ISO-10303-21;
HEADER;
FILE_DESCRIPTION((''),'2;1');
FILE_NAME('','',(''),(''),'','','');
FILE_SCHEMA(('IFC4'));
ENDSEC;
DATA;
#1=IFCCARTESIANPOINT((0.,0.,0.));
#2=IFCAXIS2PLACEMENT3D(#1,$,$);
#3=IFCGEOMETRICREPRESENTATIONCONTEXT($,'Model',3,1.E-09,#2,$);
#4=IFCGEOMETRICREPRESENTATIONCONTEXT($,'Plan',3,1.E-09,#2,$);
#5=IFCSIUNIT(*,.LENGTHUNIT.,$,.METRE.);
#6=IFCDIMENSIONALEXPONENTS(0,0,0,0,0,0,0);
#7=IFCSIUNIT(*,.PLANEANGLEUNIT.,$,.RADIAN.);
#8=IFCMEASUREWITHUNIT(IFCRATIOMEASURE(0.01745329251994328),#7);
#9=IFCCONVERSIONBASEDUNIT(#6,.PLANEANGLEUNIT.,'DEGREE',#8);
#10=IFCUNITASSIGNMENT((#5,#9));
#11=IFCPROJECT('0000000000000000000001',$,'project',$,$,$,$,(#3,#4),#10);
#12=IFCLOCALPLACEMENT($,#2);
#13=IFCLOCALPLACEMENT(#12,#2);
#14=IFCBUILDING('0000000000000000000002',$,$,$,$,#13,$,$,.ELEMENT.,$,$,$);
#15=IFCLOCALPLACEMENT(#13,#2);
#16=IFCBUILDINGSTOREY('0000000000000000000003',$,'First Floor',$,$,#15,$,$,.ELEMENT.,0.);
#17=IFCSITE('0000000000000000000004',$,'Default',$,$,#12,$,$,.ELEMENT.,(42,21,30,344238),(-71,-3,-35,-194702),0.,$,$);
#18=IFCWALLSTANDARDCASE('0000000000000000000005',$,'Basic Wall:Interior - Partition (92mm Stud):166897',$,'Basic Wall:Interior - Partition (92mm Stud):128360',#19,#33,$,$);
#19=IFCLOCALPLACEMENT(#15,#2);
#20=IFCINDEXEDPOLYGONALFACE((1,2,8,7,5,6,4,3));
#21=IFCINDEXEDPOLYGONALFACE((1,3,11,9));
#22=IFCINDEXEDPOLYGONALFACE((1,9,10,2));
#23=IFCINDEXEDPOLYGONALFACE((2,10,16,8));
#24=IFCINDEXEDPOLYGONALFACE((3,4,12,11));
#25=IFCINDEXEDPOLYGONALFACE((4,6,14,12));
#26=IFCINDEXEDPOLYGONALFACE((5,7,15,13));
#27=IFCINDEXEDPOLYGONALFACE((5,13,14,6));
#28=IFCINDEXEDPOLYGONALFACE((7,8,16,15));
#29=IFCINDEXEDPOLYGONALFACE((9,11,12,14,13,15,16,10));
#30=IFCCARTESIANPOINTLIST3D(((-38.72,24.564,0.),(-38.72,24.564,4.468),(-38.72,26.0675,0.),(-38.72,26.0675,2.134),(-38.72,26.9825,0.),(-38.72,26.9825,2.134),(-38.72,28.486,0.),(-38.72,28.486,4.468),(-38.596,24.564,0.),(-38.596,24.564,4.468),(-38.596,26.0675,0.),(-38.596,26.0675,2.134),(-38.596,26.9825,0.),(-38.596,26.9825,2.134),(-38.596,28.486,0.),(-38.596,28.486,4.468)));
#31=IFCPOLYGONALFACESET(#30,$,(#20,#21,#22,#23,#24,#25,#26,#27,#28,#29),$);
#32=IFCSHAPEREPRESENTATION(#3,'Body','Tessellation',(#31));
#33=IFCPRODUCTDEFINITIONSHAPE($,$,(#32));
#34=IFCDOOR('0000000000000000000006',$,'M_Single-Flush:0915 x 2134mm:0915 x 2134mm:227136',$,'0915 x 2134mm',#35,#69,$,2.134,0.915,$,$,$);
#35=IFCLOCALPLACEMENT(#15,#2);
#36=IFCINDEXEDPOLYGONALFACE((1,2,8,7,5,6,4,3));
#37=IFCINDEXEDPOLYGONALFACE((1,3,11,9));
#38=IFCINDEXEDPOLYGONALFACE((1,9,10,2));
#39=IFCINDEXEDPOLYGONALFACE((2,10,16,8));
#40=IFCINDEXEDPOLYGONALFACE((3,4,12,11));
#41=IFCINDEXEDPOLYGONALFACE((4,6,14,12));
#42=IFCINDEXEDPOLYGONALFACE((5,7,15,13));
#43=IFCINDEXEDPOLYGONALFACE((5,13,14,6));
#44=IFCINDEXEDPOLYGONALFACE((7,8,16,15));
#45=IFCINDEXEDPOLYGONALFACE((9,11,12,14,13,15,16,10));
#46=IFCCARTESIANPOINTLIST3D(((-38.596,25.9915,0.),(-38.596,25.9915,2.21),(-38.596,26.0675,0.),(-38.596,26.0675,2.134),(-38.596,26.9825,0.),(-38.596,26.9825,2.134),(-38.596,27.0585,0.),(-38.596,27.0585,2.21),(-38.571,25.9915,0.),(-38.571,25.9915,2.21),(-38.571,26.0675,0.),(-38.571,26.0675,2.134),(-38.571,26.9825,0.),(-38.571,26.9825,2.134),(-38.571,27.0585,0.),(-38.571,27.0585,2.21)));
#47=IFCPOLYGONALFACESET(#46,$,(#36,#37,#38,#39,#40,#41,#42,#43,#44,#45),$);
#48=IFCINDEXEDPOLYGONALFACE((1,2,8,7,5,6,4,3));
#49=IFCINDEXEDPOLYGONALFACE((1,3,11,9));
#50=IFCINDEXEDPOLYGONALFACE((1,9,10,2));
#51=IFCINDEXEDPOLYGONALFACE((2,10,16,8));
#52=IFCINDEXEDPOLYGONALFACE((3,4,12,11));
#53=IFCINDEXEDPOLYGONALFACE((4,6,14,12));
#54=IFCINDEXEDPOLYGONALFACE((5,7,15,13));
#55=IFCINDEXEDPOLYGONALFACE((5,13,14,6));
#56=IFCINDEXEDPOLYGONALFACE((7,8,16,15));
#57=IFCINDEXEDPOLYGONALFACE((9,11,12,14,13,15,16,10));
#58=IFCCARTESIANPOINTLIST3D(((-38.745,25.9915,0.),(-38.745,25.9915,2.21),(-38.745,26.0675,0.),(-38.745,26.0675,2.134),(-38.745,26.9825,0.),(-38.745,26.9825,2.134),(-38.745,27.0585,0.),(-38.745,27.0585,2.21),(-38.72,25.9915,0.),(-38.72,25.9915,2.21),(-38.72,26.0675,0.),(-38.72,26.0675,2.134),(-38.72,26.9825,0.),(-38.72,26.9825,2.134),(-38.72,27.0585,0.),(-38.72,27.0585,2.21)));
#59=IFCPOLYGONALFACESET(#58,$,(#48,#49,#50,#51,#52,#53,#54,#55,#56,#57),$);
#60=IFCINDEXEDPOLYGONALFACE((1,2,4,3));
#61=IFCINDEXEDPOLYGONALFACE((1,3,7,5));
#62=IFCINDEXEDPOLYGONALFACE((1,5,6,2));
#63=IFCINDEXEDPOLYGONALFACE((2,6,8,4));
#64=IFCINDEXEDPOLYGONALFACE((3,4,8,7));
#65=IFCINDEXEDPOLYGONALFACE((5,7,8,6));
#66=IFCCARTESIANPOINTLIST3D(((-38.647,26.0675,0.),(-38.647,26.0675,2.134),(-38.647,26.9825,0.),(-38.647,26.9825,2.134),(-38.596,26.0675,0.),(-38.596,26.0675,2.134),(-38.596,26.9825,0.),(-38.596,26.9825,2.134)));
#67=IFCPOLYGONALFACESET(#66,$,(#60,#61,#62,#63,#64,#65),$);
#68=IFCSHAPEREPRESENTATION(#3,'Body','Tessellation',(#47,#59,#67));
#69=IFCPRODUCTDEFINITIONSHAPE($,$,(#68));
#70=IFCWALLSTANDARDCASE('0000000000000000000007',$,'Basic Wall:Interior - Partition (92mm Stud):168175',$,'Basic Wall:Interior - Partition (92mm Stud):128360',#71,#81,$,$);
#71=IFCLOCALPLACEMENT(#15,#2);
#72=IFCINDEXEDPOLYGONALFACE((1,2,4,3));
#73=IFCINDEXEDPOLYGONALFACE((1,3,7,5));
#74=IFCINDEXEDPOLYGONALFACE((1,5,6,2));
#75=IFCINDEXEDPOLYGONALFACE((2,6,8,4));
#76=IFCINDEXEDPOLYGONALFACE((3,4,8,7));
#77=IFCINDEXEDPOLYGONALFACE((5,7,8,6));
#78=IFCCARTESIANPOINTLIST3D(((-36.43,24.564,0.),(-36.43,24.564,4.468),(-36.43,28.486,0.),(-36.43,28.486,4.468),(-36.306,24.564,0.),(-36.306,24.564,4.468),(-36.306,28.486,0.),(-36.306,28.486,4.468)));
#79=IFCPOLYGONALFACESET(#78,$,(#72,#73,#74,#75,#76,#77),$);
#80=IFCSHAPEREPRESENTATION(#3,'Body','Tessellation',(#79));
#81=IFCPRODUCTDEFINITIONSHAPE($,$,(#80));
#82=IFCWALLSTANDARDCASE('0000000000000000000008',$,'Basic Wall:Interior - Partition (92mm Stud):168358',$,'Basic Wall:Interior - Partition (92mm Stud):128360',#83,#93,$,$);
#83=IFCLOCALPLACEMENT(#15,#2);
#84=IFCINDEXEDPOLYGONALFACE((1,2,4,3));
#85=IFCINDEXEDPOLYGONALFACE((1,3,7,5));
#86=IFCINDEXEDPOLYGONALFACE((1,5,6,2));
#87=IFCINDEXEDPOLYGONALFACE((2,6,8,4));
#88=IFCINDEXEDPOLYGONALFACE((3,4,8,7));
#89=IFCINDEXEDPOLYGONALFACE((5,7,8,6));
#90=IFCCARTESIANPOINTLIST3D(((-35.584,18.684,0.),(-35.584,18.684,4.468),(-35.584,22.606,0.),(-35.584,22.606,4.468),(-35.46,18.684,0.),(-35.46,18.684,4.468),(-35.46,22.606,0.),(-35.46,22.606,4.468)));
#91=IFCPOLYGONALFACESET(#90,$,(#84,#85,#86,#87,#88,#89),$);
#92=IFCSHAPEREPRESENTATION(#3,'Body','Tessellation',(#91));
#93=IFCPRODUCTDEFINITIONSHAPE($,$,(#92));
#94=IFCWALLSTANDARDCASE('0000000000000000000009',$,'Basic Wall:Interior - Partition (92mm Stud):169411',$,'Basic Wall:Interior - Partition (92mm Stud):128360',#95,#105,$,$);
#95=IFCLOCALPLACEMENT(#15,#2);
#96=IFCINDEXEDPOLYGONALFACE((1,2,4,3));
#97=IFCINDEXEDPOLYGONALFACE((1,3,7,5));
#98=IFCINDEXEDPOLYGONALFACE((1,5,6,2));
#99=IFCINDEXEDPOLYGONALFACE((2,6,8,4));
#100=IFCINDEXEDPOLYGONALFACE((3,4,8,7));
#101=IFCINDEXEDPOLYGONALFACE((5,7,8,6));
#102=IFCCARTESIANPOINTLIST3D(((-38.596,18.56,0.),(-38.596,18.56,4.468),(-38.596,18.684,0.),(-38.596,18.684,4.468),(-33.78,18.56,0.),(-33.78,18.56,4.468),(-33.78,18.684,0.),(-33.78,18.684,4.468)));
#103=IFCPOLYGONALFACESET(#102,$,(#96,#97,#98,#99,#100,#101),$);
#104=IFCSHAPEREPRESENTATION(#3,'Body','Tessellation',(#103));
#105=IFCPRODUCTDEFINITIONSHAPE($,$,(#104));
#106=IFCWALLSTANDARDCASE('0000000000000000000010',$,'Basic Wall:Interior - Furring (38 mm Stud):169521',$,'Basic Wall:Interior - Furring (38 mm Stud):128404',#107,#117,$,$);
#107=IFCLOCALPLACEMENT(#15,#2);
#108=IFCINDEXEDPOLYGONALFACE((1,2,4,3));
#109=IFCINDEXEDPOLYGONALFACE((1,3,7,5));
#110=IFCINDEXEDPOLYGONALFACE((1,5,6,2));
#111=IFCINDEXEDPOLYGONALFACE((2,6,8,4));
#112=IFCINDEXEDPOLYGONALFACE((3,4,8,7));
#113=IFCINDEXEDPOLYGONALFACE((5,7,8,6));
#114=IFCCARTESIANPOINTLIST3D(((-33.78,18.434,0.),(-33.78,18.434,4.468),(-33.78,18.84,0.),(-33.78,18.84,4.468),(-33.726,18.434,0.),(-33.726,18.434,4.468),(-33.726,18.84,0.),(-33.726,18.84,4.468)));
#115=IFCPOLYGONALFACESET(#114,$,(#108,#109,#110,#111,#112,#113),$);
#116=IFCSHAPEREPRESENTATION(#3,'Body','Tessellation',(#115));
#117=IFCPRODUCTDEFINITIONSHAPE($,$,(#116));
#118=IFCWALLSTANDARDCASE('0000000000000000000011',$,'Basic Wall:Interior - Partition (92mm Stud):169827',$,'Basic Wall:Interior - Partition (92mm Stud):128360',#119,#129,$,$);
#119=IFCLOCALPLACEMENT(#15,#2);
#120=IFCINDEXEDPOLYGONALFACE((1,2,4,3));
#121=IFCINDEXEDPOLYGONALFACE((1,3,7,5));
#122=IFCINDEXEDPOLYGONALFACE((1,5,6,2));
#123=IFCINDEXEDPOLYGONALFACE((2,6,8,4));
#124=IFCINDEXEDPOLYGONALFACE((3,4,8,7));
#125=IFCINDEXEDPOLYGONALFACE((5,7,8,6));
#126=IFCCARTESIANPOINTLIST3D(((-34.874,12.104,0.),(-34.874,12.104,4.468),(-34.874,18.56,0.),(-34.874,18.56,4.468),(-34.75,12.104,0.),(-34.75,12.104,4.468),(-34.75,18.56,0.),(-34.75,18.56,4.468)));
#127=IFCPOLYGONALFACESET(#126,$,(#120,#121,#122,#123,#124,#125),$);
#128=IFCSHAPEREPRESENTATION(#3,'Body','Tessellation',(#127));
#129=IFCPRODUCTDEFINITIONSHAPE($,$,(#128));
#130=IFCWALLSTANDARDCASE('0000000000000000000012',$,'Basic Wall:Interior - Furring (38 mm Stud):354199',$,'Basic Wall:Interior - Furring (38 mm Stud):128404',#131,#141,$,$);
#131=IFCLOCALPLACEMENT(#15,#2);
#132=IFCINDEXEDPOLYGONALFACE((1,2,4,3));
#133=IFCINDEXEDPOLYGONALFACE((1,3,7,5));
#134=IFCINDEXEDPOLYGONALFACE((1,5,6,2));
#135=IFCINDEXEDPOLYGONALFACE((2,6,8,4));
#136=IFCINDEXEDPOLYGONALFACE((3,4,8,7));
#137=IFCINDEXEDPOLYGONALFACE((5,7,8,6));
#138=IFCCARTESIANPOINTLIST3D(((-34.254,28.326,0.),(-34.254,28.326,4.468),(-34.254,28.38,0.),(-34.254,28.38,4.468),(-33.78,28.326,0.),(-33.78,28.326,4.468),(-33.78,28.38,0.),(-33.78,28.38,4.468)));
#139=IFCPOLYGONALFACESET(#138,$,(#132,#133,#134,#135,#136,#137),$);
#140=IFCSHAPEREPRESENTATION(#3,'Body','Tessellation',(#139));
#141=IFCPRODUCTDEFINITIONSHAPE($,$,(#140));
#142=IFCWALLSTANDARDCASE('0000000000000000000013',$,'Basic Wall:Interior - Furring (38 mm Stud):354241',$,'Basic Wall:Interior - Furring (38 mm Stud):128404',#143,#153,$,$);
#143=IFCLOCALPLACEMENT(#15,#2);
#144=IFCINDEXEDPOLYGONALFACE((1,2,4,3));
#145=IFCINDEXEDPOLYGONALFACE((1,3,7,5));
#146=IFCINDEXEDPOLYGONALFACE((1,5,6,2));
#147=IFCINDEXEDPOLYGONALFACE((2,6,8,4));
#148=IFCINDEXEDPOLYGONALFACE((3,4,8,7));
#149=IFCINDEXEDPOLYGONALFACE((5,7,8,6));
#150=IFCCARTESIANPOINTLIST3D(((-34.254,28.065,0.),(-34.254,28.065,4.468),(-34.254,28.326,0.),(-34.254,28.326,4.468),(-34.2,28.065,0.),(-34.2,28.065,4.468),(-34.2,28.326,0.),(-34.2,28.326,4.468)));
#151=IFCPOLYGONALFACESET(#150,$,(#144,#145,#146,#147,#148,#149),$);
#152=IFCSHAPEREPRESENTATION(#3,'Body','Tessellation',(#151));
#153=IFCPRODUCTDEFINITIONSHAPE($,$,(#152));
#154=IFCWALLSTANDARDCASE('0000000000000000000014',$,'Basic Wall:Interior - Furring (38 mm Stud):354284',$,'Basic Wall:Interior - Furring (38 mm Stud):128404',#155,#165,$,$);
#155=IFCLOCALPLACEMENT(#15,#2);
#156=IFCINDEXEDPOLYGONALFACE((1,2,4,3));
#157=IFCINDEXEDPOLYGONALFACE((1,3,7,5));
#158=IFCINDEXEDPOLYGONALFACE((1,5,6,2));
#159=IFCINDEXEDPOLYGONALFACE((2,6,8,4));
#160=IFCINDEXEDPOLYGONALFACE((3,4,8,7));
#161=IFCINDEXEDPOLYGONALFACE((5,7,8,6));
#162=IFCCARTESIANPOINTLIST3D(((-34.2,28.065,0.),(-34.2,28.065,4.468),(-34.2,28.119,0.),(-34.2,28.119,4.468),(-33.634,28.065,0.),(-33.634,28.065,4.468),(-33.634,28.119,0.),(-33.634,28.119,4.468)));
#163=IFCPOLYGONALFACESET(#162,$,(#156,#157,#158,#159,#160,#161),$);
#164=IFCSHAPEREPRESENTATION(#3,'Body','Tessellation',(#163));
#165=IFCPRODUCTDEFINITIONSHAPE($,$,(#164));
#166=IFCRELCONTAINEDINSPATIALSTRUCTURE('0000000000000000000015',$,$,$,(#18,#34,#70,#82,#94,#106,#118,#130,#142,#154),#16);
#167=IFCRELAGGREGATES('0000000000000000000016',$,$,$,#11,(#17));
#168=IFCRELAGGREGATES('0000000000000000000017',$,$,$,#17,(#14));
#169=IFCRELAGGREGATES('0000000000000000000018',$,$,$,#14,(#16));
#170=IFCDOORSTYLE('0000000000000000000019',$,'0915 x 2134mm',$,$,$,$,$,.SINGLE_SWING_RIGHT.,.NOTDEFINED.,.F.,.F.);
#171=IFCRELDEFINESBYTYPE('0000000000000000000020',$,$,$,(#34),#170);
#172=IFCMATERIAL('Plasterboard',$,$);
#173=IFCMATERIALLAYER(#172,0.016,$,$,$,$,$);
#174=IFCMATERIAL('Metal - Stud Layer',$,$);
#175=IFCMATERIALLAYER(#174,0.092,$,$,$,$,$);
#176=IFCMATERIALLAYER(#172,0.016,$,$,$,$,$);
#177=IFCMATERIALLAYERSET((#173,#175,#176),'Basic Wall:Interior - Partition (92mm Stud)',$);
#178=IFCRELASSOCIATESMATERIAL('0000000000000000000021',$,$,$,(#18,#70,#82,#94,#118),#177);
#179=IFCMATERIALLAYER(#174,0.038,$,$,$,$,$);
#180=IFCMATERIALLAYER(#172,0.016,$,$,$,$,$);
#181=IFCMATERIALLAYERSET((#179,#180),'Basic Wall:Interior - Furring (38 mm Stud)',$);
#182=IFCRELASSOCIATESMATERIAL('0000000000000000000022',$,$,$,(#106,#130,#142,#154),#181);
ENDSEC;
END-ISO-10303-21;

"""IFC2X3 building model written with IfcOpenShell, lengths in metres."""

from ifc_helpers import new_model, entity, si_unit, converted_unit, frame, frame_2d, origin, origin_2d_with_axis, place, context, project, spatial, polyline, rectangle, outline, extrude, source, transform, mapped, material, layer, layer_set, layer_usage, type_object, type_shapes, element, fill, save


model = new_model("IFC2X3")

# Units and contexts
model_context = context("Model", 3, precision=1e-09, world=origin())
plan_context = context("Plan", 3, precision=1e-09, world=origin())
ifc_project = project(units=[si_unit("LENGTHUNIT", "METRE"), converted_unit("PLANEANGLEUNIT", "DEGREE", entity("IfcRatioMeasure", 0.01745329251994328), si_unit("PLANEANGLEUNIT", "RADIAN"), dimensions=[0, 0, 0, 0, 0, 0, 0])], contexts=[model_context, plan_context])

# Site, building, storey
site_placement = place(None, origin())
site = spatial("IfcSite", under=ifc_project, at=site_placement, Name="Default", CompositionType="ELEMENT", RefLatitude=(42, 21, 30, 344238), RefLongitude=(-71, -3, -35, -194702), RefElevation=0.0)
building_placement = place(site_placement, origin())
building = spatial("IfcBuilding", under=site, at=building_placement, CompositionType="ELEMENT")
storey_placement = place(building_placement, origin())
storey = spatial("IfcBuildingStorey", under=building, at=storey_placement, Name="First Floor", CompositionType="ELEMENT", Elevation=0.0)

# Shared definitions
ifc_material_1 = material(Name="Plasterboard")
ifc_layer_1 = layer(ifc_material_1, 0.016)
ifc_material_2 = material(Name="Metal - Stud Layer")
ifc_layer_2 = layer(ifc_material_2, 0.092)
ifc_layer_3 = layer(ifc_material_1, 0.016)
ifc_layer_set_1 = layer_set([ifc_layer_1, ifc_layer_2, ifc_layer_3], Name="Basic Wall:Interior - Partition (92mm Stud)")
door_style_1 = type_object("IfcDoorStyle", Name="0915 x 2134mm", ConstructionType="NOTDEFINED", OperationType="SINGLE_SWING_RIGHT", ParameterTakesPrecedence=False, Sizeable=False)
shared_shape_1 = source(origin(), model_context, "Body", "SweptSolid", [
    extrude(outline(polyline([(-0.5335, -1.124), (0.5335, -1.124), (0.5335, 1.086), (0.4575, 1.086), (0.4575, -1.048), (-0.4575, -1.048), (-0.4575, 1.086), (-0.5335, 1.086), (-0.5335, -1.124)])), frame((0.4575, 0.124, 1.086), z_axis=(0.0, 1.0, 0.0), x_axis=(1.0, 0.0, 0.0)), (0.0, 0.0, 1.0), 0.025),
    extrude(outline(polyline([(-1.124, -0.5335), (1.086, -0.5335), (1.086, -0.4575), (-1.048, -0.4575), (-1.048, 0.4575), (1.086, 0.4575), (1.086, 0.5335), (-1.124, 0.5335), (-1.124, -0.5335)])), frame((0.4575, -0.025, 1.086), z_axis=(0.0, 1.0, 0.0), x_axis=(0.0, 0.0, -1.0)), (0.0, 0.0, 1.0), 0.025),
    extrude(rectangle(XDim=0.051, YDim=0.915, at=origin_2d_with_axis()), frame((0.4575, 0.0985, 0.0), z_axis=(0.0, 0.0, 1.0), x_axis=(0.0, 1.0, 0.0)), (0.0, 0.0, 1.0), 2.134),
])
type_shapes(door_style_1, [shared_shape_1])

# Wall, opening, door
ifc_layer_usage_1 = layer_usage(ifc_layer_set_1, "AXIS2", "NEGATIVE", 0.062)
wall_1_placement = place(storey_placement, frame((-38.658, 24.564, 0.0), z_axis=(0.0, 0.0, 1.0), x_axis=(0.0, 1.0, 0.0)))
wall_1 = element("IfcWallStandardCase", 1, at=wall_1_placement, inside=storey, material=ifc_layer_usage_1, Name="Basic Wall:Interior - Partition (92mm Stud):166897", ObjectType="Basic Wall:Interior - Partition (92mm Stud):128360", context=model_context, shape_type="SweptSolid", body=[
    extrude(rectangle(XDim=3.922, YDim=0.124, at=frame_2d((1.961, 0.0), x_axis=(-1.0, 0.0))), origin(), (0.0, 0.0, 1.0), 4.468),
])
opening_1_placement = place(wall_1_placement, frame((2.4185, 0.062, 0.0)))
opening_1 = element("IfcOpeningElement", 2, at=opening_1_placement, cuts=wall_1, ObjectType="Opening", context=model_context, shape_type="SweptSolid", body=[
    extrude(rectangle(XDim=0.915, YDim=2.134, at=frame_2d((1.067, 0.4575), x_axis=(0.0, 1.0))), frame((0.0, 0.0, 0.0), z_axis=(0.0, -1.0, 0.0), x_axis=(0.0, 0.0, 1.0)), (0.0, 0.0, 1.0), 0.124),
])
door_1_placement = place(opening_1_placement, frame((0.0, 0.0, 0.0), z_axis=(0.0, 0.0, 1.0), x_axis=(-1.0, 0.0, 0.0)))
door_1 = element("IfcDoor", 3, at=door_1_placement, inside=storey, type_object=door_style_1, Name="M_Single-Flush:0915 x 2134mm:0915 x 2134mm:227136", ObjectType="0915 x 2134mm", OverallHeight=2.134, OverallWidth=0.915, context=model_context, shape_type="MappedRepresentation", body=[
    mapped(shared_shape_1, transform((0.0, 0.0, 0.0), scale=1.0)),
])
fill(opening_1, door_1)

# Walls
ifc_layer_usage_2 = layer_usage(ifc_layer_set_1, "AXIS2", "NEGATIVE", 0.062)
wall_2_placement = place(storey_placement, frame((-36.368, 24.564, 0.0), z_axis=(0.0, 0.0, 1.0), x_axis=(0.0, 1.0, 0.0)))
element("IfcWallStandardCase", 4, at=wall_2_placement, inside=storey, material=ifc_layer_usage_2, Name="Basic Wall:Interior - Partition (92mm Stud):168175", ObjectType="Basic Wall:Interior - Partition (92mm Stud):128360", context=model_context, shape_type="SweptSolid", body=[
    extrude(rectangle(XDim=3.922, YDim=0.124, at=frame_2d((1.961, 0.0), x_axis=(-1.0, 0.0))), origin(), (0.0, 0.0, 1.0), 4.468),
])
ifc_layer_usage_3 = layer_usage(ifc_layer_set_1, "AXIS2", "NEGATIVE", 0.062)
wall_3_placement = place(storey_placement, frame((-35.522, 22.606, 0.0), z_axis=(0.0, 0.0, 1.0), x_axis=(0.0, -1.0, 0.0)))
element("IfcWallStandardCase", 5, at=wall_3_placement, inside=storey, material=ifc_layer_usage_3, Name="Basic Wall:Interior - Partition (92mm Stud):168358", ObjectType="Basic Wall:Interior - Partition (92mm Stud):128360", context=model_context, shape_type="SweptSolid", body=[
    extrude(rectangle(XDim=3.922, YDim=0.124, at=frame_2d((1.961, 0.0), x_axis=(-1.0, 0.0))), origin(), (0.0, 0.0, 1.0), 4.468),
])
ifc_layer_usage_4 = layer_usage(ifc_layer_set_1, "AXIS2", "NEGATIVE", 0.062)
wall_4_placement = place(storey_placement, frame((-33.78, 18.622, 0.0), z_axis=(0.0, 0.0, 1.0), x_axis=(-1.0, 0.0, 0.0)))
element("IfcWallStandardCase", 6, at=wall_4_placement, inside=storey, material=ifc_layer_usage_4, Name="Basic Wall:Interior - Partition (92mm Stud):169411", ObjectType="Basic Wall:Interior - Partition (92mm Stud):128360", context=model_context, shape_type="SweptSolid", body=[
    extrude(rectangle(XDim=4.816, YDim=0.124, at=frame_2d((2.408, 0.0), x_axis=(-1.0, 0.0))), origin(), (0.0, 0.0, 1.0), 4.468),
])
ifc_layer_4 = layer(ifc_material_2, 0.038)
ifc_layer_5 = layer(ifc_material_1, 0.016)
ifc_layer_set_2 = layer_set([ifc_layer_4, ifc_layer_5], Name="Basic Wall:Interior - Furring (38 mm Stud)")
ifc_layer_usage_5 = layer_usage(ifc_layer_set_2, "AXIS2", "POSITIVE", -0.027)
wall_5_placement = place(storey_placement, frame((-33.753, 18.434, 0.0), z_axis=(0.0, 0.0, 1.0), x_axis=(0.0, 1.0, 0.0)))
element("IfcWallStandardCase", 7, at=wall_5_placement, inside=storey, material=ifc_layer_usage_5, Name="Basic Wall:Interior - Furring (38 mm Stud):169521", ObjectType="Basic Wall:Interior - Furring (38 mm Stud):128404", context=model_context, shape_type="SweptSolid", body=[
    extrude(rectangle(XDim=0.406, YDim=0.054, at=frame_2d((0.203, 0.0), x_axis=(-1.0, 0.0))), origin(), (0.0, 0.0, 1.0), 4.468),
])
ifc_layer_usage_6 = layer_usage(ifc_layer_set_1, "AXIS2", "NEGATIVE", 0.062)
wall_6_placement = place(storey_placement, frame((-34.812, 18.56, 0.0), z_axis=(0.0, 0.0, 1.0), x_axis=(0.0, -1.0, 0.0)))
element("IfcWallStandardCase", 8, at=wall_6_placement, inside=storey, material=ifc_layer_usage_6, Name="Basic Wall:Interior - Partition (92mm Stud):169827", ObjectType="Basic Wall:Interior - Partition (92mm Stud):128360", context=model_context, shape_type="SweptSolid", body=[
    extrude(rectangle(XDim=6.456, YDim=0.124, at=frame_2d((3.228, 0.0), x_axis=(-1.0, 0.0))), origin(), (0.0, 0.0, 1.0), 4.468),
])
ifc_layer_usage_7 = layer_usage(ifc_layer_set_2, "AXIS2", "NEGATIVE", 0.027)
wall_7_placement = place(storey_placement, frame((-33.78, 28.353, 0.0), z_axis=(0.0, 0.0, 1.0), x_axis=(-1.0, 0.0, 0.0)))
element("IfcWallStandardCase", 9, at=wall_7_placement, inside=storey, material=ifc_layer_usage_7, Name="Basic Wall:Interior - Furring (38 mm Stud):354199", ObjectType="Basic Wall:Interior - Furring (38 mm Stud):128404", context=model_context, shape_type="SweptSolid", body=[
    extrude(rectangle(XDim=0.474, YDim=0.054, at=frame_2d((0.237, 0.0), x_axis=(-1.0, 0.0))), origin(), (0.0, 0.0, 1.0), 4.468),
])
ifc_layer_usage_8 = layer_usage(ifc_layer_set_2, "AXIS2", "NEGATIVE", 0.027)
wall_8_placement = place(storey_placement, frame((-34.227, 28.326, 0.0), z_axis=(0.0, 0.0, 1.0), x_axis=(0.0, -1.0, 0.0)))
element("IfcWallStandardCase", 10, at=wall_8_placement, inside=storey, material=ifc_layer_usage_8, Name="Basic Wall:Interior - Furring (38 mm Stud):354241", ObjectType="Basic Wall:Interior - Furring (38 mm Stud):128404", context=model_context, shape_type="SweptSolid", body=[
    extrude(rectangle(XDim=0.261, YDim=0.054, at=frame_2d((0.1305, 0.0), x_axis=(-1.0, 0.0))), origin(), (0.0, 0.0, 1.0), 4.468),
])
ifc_layer_usage_9 = layer_usage(ifc_layer_set_2, "AXIS2", "NEGATIVE", 0.027)
wall_9_placement = place(storey_placement, frame((-34.2, 28.092, 0.0)))
element("IfcWallStandardCase", 11, at=wall_9_placement, inside=storey, material=ifc_layer_usage_9, Name="Basic Wall:Interior - Furring (38 mm Stud):354284", ObjectType="Basic Wall:Interior - Furring (38 mm Stud):128404", context=model_context, shape_type="SweptSolid", body=[
    extrude(rectangle(XDim=0.566, YDim=0.054, at=frame_2d((0.283, 0.0), x_axis=(-1.0, 0.0))), origin(), (0.0, 0.0, 1.0), 4.468),
])

save(model, "model.ifc")
